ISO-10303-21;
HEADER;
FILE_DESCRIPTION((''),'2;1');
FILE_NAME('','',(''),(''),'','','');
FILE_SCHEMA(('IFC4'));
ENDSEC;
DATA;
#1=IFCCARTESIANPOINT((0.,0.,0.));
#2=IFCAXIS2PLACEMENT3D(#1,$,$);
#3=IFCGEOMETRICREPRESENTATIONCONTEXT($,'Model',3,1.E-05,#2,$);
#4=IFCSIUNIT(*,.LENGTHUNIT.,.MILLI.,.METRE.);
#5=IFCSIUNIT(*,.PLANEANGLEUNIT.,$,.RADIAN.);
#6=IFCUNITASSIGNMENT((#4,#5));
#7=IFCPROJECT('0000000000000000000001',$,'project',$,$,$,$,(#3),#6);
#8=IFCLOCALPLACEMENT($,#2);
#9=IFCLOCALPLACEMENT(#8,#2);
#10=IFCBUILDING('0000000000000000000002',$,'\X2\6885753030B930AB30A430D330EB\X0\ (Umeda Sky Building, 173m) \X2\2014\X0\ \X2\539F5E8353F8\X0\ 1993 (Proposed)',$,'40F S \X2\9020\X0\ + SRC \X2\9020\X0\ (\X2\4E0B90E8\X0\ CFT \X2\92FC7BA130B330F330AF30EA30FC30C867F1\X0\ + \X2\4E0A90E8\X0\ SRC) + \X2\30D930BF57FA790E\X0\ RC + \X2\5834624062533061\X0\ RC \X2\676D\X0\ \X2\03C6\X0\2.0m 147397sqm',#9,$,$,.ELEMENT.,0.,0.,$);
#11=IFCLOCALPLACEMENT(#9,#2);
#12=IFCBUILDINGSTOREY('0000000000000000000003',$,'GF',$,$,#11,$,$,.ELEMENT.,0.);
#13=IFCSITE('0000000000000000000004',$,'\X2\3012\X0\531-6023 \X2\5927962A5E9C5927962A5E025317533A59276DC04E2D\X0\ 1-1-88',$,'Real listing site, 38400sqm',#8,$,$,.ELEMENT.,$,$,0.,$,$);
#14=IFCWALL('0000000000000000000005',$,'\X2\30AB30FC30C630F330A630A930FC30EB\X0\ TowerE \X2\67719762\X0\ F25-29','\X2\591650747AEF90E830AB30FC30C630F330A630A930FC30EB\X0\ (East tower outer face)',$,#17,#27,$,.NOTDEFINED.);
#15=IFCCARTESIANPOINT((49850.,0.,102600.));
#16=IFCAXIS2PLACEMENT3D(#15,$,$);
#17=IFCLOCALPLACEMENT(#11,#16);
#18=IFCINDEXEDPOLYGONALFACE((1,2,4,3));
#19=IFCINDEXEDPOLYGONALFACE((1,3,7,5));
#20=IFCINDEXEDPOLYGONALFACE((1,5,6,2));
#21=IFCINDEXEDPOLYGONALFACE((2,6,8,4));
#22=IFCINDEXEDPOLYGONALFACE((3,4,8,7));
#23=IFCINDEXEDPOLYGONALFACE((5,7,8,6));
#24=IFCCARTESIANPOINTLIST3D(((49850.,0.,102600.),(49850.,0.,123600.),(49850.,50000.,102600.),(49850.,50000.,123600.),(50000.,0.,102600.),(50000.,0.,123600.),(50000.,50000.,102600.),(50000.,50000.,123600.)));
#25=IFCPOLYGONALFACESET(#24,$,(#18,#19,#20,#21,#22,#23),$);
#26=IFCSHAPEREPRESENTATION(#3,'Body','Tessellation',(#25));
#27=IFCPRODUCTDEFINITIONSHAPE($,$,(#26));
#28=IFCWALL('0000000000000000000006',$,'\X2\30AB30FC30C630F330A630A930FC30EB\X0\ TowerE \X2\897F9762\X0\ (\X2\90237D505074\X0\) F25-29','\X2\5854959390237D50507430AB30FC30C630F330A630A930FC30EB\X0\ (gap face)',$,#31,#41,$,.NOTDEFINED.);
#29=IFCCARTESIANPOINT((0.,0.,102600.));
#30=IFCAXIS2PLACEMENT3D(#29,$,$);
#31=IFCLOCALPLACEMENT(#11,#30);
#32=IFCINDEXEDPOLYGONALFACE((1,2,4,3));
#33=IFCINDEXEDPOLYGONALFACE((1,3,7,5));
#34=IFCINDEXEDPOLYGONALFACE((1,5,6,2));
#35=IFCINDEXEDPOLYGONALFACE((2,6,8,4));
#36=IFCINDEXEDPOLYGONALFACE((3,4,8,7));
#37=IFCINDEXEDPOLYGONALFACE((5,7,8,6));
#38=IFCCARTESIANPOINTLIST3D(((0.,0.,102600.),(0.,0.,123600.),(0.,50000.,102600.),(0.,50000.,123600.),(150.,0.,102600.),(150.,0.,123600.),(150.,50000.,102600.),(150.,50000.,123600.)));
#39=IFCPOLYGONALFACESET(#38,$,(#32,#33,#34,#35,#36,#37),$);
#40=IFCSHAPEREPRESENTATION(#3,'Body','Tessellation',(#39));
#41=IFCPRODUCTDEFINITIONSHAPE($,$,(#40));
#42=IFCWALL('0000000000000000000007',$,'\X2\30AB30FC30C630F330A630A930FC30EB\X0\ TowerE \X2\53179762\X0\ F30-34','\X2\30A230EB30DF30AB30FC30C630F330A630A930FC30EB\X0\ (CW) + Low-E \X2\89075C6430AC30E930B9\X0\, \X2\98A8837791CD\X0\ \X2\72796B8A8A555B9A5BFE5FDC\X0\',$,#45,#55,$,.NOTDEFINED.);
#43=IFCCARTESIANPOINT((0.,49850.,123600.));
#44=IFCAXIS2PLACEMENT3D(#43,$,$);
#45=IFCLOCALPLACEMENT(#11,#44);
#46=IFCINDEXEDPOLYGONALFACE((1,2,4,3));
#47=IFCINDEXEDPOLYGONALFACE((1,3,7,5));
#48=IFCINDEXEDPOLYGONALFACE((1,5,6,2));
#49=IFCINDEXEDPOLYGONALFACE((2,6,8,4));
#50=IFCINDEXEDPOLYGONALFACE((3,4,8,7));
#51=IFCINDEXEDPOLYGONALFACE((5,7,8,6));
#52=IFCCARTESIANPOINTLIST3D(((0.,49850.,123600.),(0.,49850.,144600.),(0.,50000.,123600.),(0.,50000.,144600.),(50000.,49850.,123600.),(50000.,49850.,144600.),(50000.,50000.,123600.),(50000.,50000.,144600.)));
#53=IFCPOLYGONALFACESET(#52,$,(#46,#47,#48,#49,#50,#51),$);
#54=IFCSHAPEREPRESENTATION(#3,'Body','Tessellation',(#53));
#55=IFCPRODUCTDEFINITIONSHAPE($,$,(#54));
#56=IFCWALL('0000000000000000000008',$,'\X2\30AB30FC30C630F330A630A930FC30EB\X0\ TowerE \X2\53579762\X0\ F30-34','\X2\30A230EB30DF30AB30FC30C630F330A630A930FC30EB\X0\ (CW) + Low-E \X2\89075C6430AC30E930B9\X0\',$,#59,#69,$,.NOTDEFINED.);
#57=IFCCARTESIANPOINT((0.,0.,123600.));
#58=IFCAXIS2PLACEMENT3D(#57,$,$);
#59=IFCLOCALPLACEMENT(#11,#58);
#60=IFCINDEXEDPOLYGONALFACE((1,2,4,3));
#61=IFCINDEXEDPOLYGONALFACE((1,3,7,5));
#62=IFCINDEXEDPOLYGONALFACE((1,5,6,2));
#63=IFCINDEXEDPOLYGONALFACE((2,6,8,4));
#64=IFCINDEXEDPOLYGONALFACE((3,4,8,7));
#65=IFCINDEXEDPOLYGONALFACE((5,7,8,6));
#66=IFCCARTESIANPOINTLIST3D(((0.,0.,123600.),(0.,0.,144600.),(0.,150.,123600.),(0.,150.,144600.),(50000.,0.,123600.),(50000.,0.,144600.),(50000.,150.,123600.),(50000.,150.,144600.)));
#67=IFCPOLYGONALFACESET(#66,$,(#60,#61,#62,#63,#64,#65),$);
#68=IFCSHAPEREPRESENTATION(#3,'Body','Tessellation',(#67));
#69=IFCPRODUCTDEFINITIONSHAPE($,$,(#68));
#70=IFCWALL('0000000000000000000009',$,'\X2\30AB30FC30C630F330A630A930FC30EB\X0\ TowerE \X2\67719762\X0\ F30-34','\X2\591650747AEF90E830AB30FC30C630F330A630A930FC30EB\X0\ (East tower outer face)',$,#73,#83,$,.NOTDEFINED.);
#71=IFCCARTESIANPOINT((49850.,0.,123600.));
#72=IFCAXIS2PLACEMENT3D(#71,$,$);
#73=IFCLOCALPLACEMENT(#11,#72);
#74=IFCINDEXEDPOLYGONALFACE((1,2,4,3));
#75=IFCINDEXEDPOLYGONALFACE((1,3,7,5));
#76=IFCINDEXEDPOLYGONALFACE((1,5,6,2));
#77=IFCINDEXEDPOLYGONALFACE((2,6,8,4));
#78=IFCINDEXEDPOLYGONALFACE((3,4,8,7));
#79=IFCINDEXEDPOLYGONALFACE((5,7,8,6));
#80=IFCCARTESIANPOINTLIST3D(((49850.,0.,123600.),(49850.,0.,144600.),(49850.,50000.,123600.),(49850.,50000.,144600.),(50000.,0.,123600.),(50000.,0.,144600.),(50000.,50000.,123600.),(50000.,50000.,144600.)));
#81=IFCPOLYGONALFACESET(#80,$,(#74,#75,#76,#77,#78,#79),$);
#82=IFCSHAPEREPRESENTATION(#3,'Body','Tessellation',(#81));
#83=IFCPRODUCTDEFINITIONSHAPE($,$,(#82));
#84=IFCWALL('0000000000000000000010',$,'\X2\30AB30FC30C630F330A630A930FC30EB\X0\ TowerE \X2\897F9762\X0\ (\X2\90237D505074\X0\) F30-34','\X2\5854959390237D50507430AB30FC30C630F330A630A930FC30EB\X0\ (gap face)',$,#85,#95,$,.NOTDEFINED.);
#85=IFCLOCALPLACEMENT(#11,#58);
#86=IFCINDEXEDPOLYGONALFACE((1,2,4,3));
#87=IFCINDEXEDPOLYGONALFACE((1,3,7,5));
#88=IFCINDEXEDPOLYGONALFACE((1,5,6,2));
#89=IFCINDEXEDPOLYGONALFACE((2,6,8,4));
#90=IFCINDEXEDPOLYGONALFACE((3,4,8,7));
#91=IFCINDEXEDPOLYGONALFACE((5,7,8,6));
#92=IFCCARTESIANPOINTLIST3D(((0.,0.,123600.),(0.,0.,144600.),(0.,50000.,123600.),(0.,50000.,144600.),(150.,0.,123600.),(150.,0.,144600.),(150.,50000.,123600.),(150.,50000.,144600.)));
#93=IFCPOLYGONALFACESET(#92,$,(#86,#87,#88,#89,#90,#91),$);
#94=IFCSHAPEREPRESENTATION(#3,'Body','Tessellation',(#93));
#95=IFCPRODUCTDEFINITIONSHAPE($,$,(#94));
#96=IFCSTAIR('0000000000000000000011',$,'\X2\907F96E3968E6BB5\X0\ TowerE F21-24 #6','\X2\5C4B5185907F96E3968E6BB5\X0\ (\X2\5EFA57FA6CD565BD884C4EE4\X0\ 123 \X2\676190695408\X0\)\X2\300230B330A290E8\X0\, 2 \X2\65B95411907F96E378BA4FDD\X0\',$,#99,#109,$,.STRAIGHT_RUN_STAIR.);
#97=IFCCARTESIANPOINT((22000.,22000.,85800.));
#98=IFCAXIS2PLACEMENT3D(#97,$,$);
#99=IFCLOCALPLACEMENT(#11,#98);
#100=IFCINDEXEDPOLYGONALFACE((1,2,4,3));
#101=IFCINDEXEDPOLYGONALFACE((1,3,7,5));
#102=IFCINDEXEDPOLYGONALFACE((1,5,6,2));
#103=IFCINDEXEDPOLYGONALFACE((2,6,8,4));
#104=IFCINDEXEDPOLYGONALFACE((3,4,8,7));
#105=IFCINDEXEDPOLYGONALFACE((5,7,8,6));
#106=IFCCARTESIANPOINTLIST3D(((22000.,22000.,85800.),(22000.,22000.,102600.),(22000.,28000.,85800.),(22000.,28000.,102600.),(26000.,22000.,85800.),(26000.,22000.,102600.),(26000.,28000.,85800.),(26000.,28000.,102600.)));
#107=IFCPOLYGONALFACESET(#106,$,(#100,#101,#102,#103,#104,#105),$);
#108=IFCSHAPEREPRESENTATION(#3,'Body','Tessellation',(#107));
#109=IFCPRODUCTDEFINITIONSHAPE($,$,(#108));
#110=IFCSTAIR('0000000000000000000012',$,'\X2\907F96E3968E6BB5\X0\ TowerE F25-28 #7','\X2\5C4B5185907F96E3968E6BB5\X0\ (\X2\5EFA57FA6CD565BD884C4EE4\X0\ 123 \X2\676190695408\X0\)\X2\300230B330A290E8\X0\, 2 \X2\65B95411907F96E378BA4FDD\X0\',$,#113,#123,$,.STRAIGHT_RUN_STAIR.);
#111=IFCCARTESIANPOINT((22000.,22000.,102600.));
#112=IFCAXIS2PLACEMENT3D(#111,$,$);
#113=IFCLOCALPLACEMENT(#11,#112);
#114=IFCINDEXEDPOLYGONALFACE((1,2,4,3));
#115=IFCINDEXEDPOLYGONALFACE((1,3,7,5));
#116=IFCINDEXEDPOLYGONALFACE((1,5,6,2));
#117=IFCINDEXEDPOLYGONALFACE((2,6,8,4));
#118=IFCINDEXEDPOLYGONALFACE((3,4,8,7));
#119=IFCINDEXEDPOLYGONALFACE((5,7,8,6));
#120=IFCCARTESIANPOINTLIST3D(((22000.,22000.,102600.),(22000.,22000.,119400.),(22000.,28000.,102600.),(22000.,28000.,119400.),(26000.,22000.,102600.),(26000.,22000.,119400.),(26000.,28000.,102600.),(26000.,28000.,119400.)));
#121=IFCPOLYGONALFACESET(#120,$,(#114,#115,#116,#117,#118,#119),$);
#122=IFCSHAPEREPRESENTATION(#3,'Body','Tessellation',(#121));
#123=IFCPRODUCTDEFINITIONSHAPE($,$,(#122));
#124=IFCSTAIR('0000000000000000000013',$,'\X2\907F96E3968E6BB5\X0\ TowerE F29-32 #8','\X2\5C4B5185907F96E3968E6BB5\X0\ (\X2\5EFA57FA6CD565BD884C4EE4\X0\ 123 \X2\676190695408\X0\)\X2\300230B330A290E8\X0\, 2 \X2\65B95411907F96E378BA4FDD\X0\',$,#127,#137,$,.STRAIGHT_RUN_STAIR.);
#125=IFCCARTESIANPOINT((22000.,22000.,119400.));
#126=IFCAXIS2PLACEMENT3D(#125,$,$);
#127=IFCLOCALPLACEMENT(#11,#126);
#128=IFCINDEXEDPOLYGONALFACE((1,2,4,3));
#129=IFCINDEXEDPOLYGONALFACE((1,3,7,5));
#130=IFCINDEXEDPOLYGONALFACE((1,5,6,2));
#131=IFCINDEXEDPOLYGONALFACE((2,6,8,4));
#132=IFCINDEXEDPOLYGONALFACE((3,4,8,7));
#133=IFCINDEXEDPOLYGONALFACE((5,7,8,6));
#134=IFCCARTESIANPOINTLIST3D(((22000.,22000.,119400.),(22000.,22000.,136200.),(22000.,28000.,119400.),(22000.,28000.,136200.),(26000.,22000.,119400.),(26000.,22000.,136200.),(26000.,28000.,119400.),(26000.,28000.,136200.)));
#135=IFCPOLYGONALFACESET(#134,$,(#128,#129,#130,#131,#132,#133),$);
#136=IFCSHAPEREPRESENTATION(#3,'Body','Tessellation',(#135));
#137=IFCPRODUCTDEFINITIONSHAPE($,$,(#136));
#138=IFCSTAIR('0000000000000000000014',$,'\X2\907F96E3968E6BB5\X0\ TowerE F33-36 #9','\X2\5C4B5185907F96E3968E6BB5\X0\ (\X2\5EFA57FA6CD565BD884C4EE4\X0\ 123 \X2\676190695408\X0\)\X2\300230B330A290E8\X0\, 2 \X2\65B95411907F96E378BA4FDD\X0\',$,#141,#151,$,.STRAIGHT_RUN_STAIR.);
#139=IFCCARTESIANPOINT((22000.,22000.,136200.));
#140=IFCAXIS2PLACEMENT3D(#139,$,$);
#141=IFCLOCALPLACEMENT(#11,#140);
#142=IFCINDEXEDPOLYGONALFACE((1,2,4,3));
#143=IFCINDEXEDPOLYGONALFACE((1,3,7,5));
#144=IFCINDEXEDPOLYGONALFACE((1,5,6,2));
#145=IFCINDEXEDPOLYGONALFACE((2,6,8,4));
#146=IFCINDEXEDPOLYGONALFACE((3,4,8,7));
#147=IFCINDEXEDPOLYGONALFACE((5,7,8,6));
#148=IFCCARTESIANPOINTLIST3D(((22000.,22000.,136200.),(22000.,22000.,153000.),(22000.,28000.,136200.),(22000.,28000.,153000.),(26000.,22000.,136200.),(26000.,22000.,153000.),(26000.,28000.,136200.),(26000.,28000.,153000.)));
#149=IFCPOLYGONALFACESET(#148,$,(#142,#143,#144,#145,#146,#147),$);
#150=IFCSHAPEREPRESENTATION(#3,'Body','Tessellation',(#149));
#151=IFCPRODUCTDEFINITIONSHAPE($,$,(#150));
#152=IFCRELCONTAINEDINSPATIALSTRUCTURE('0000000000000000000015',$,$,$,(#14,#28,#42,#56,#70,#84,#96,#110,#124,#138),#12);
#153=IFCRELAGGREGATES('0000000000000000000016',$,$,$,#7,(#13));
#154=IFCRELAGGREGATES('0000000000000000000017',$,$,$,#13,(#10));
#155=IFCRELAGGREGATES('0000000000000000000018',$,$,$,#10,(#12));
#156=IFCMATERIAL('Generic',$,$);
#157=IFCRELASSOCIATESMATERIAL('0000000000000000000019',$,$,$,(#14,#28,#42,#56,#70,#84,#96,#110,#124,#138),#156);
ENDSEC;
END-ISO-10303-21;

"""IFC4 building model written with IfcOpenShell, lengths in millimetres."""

from ifc_helpers import new_model, si_unit, frame, frame_2d, origin, place, context, project, spatial, rectangle, extrude, material, element, save


model = new_model("IFC4")

# Units and contexts
model_context = context("Model", 3, precision=1e-05, world=origin())
ifc_project = project(units=[si_unit("LENGTHUNIT", "METRE", prefix="MILLI"), si_unit("PLANEANGLEUNIT", "RADIAN")], contexts=[model_context])

# Site, building, storey
site_placement = place(None, origin())
site = spatial("IfcSite", under=ifc_project, at=site_placement, Name="〒531-6023 大阪府大阪市北区大淀中 1-1-88", ObjectType="Real listing site, 38400sqm", CompositionType="ELEMENT", RefElevation=0.0)
building_placement = place(site_placement, origin())
building = spatial("IfcBuilding", under=site, at=building_placement, Name="梅田スカイビル (Umeda Sky Building, 173m) — 原広司 1993 (Proposed)", ObjectType="40F S 造 + SRC 造 (下部 CFT 鋼管コンクリート柱 + 上部 SRC) + ベタ基礎 RC + 場所打ち RC 杭 φ2.0m 147397sqm", CompositionType="ELEMENT", ElevationOfRefHeight=0.0, ElevationOfTerrain=0.0)
storey_placement = place(building_placement, origin())
storey = spatial("IfcBuildingStorey", under=building, at=storey_placement, Name="GF", CompositionType="ELEMENT", Elevation=0.0)

# Walls
ifc_material_1 = material(Name="Generic")
wall_1_placement = place(storey_placement, frame((49850.0, 0.0, 102600.0)))
element("IfcWall", 1, at=wall_1_placement, inside=storey, material=ifc_material_1, Name="カーテンウォール TowerE 東面 F25-29", Description="外側端部カーテンウォール (East tower outer face)", PredefinedType="NOTDEFINED", context=model_context, shape_type="SweptSolid", body=[
    extrude(rectangle(XDim=150.0, YDim=50000.0, at=frame_2d((75.0, 25000.0))), frame((49850.0, 0.0, 102600.0)), (0.0, 0.0, 1.0), 21000.0),
])
wall_2_placement = place(storey_placement, frame((0.0, 0.0, 102600.0)))
element("IfcWall", 2, at=wall_2_placement, inside=storey, material=ifc_material_1, Name="カーテンウォール TowerE 西面 (連結側) F25-29", Description="塔間連結側カーテンウォール (gap face)", PredefinedType="NOTDEFINED", context=model_context, shape_type="SweptSolid", body=[
    extrude(rectangle(XDim=150.0, YDim=50000.0, at=frame_2d((75.0, 25000.0))), frame((0.0, 0.0, 102600.0)), (0.0, 0.0, 1.0), 21000.0),
])
wall_3_placement = place(storey_placement, frame((0.0, 49850.0, 123600.0)))
element("IfcWall", 3, at=wall_3_placement, inside=storey, material=ifc_material_1, Name="カーテンウォール TowerE 北面 F30-34", Description="アルミカーテンウォール (CW) + Low-E 複層ガラス, 風荷重 特殊評定対応", PredefinedType="NOTDEFINED", context=model_context, shape_type="SweptSolid", body=[
    extrude(rectangle(XDim=50000.0, YDim=150.0, at=frame_2d((25000.0, 75.0))), frame((0.0, 49850.0, 123600.0)), (0.0, 0.0, 1.0), 21000.0),
])
wall_4_placement = place(storey_placement, frame((0.0, 0.0, 123600.0)))
element("IfcWall", 4, at=wall_4_placement, inside=storey, material=ifc_material_1, Name="カーテンウォール TowerE 南面 F30-34", Description="アルミカーテンウォール (CW) + Low-E 複層ガラス", PredefinedType="NOTDEFINED", context=model_context, shape_type="SweptSolid", body=[
    extrude(rectangle(XDim=50000.0, YDim=150.0, at=frame_2d((25000.0, 75.0))), frame((0.0, 0.0, 123600.0)), (0.0, 0.0, 1.0), 21000.0),
])
wall_5_placement = place(storey_placement, frame((49850.0, 0.0, 123600.0)))
element("IfcWall", 5, at=wall_5_placement, inside=storey, material=ifc_material_1, Name="カーテンウォール TowerE 東面 F30-34", Description="外側端部カーテンウォール (East tower outer face)", PredefinedType="NOTDEFINED", context=model_context, shape_type="SweptSolid", body=[
    extrude(rectangle(XDim=150.0, YDim=50000.0, at=frame_2d((75.0, 25000.0))), frame((49850.0, 0.0, 123600.0)), (0.0, 0.0, 1.0), 21000.0),
])
wall_6_placement = place(storey_placement, frame((0.0, 0.0, 123600.0)))
element("IfcWall", 6, at=wall_6_placement, inside=storey, material=ifc_material_1, Name="カーテンウォール TowerE 西面 (連結側) F30-34", Description="塔間連結側カーテンウォール (gap face)", PredefinedType="NOTDEFINED", context=model_context, shape_type="SweptSolid", body=[
    extrude(rectangle(XDim=150.0, YDim=50000.0, at=frame_2d((75.0, 25000.0))), frame((0.0, 0.0, 123600.0)), (0.0, 0.0, 1.0), 21000.0),
])

# Stairs
stair_1_placement = place(storey_placement, frame((22000.0, 22000.0, 85800.0)))
element("IfcStair", 7, at=stair_1_placement, inside=storey, material=ifc_material_1, Name="避難階段 TowerE F21-24 #6", Description="屋内避難階段 (建基法施行令 123 条適合)。コア部, 2 方向避難確保", PredefinedType="STRAIGHT_RUN_STAIR", context=model_context, shape_type="SweptSolid", body=[
    extrude(rectangle(XDim=4000.0, YDim=6000.0, at=frame_2d((2000.0, 3000.0))), frame((22000.0, 22000.0, 85800.0)), (0.0, 0.0, 1.0), 16800.0),
])
stair_2_placement = place(storey_placement, frame((22000.0, 22000.0, 102600.0)))
element("IfcStair", 8, at=stair_2_placement, inside=storey, material=ifc_material_1, Name="避難階段 TowerE F25-28 #7", Description="屋内避難階段 (建基法施行令 123 条適合)。コア部, 2 方向避難確保", PredefinedType="STRAIGHT_RUN_STAIR", context=model_context, shape_type="SweptSolid", body=[
    extrude(rectangle(XDim=4000.0, YDim=6000.0, at=frame_2d((2000.0, 3000.0))), frame((22000.0, 22000.0, 102600.0)), (0.0, 0.0, 1.0), 16800.0),
])
stair_3_placement = place(storey_placement, frame((22000.0, 22000.0, 119400.0)))
element("IfcStair", 9, at=stair_3_placement, inside=storey, material=ifc_material_1, Name="避難階段 TowerE F29-32 #8", Description="屋内避難階段 (建基法施行令 123 条適合)。コア部, 2 方向避難確保", PredefinedType="STRAIGHT_RUN_STAIR", context=model_context, shape_type="SweptSolid", body=[
    extrude(rectangle(XDim=4000.0, YDim=6000.0, at=frame_2d((2000.0, 3000.0))), frame((22000.0, 22000.0, 119400.0)), (0.0, 0.0, 1.0), 16800.0),
])
stair_4_placement = place(storey_placement, frame((22000.0, 22000.0, 136200.0)))
element("IfcStair", 10, at=stair_4_placement, inside=storey, material=ifc_material_1, Name="避難階段 TowerE F33-36 #9", Description="屋内避難階段 (建基法施行令 123 条適合)。コア部, 2 方向避難確保", PredefinedType="STRAIGHT_RUN_STAIR", context=model_context, shape_type="SweptSolid", body=[
    extrude(rectangle(XDim=4000.0, YDim=6000.0, at=frame_2d((2000.0, 3000.0))), frame((22000.0, 22000.0, 136200.0)), (0.0, 0.0, 1.0), 16800.0),
])

save(model, "model.ifc")
